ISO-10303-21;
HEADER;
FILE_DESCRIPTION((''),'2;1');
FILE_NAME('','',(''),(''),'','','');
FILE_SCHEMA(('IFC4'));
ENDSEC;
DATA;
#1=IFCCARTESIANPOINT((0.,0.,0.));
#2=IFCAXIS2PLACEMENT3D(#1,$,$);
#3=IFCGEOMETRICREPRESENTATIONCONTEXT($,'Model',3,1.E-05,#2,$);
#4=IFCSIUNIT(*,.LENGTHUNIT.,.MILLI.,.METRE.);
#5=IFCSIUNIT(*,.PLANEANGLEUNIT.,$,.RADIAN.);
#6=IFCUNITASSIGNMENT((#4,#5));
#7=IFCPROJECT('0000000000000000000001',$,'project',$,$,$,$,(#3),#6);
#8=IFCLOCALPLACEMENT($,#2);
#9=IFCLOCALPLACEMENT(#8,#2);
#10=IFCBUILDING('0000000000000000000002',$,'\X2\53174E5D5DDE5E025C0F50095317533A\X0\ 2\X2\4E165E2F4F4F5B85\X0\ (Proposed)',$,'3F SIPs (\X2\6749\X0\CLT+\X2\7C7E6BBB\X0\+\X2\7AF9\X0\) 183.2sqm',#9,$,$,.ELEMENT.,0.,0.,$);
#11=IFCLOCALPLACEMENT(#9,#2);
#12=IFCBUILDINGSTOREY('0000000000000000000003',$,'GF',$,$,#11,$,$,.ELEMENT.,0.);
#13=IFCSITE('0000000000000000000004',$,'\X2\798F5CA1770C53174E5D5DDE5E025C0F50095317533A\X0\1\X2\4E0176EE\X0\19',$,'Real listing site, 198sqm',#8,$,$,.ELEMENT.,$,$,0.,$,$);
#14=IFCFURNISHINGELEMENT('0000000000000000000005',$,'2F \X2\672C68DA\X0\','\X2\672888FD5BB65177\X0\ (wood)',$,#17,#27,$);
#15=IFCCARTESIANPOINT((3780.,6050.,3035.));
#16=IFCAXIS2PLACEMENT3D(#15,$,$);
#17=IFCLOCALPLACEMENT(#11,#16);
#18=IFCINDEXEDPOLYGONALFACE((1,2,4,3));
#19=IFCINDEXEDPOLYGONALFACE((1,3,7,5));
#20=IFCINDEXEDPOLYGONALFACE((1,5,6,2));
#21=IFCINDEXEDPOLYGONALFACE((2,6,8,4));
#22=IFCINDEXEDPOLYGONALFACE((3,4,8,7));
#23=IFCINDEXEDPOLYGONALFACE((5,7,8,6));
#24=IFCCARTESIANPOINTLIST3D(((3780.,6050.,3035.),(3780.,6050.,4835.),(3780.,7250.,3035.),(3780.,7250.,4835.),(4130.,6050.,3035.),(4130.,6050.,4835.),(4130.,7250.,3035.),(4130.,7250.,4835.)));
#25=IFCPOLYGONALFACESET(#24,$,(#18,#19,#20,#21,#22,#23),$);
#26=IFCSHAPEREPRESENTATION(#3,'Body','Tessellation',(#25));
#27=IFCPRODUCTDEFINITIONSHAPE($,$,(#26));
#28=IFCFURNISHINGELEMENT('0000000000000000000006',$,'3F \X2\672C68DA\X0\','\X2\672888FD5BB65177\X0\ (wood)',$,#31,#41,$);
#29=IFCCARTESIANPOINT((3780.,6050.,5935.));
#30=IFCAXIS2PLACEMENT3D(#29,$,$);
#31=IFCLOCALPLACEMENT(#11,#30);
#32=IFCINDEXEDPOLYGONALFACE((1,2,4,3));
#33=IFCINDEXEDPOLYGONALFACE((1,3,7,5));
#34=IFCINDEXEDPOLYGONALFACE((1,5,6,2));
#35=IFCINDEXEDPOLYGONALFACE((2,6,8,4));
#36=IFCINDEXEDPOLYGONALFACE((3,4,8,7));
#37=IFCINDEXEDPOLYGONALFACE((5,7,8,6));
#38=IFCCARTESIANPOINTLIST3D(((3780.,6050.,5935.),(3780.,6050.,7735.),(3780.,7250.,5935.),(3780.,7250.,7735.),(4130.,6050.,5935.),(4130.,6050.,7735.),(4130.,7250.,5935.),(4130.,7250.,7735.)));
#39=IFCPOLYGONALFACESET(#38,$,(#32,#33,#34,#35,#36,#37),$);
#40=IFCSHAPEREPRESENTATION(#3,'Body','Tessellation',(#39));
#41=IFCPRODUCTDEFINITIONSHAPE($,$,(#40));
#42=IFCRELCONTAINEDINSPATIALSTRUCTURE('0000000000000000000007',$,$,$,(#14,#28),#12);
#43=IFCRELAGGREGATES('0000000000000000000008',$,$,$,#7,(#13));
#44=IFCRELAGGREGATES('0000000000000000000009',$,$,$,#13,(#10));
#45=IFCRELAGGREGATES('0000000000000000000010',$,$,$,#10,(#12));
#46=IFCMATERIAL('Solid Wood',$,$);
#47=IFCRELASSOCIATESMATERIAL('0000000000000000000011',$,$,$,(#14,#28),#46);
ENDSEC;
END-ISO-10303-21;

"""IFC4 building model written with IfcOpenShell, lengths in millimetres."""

from ifc_helpers import new_model, si_unit, frame, frame_2d, origin, place, context, project, spatial, rectangle, extrude, material, element, save


model = new_model("IFC4")

# Units and contexts
model_context = context("Model", 3, precision=1e-05, world=origin())
ifc_project = project(units=[si_unit("LENGTHUNIT", "METRE", prefix="MILLI"), si_unit("PLANEANGLEUNIT", "RADIAN")], contexts=[model_context])

# Site, building, storey
site_placement = place(None, origin())
site = spatial("IfcSite", under=ifc_project, at=site_placement, Name="福岡県北九州市小倉北区1丁目19", ObjectType="Real listing site, 198sqm", CompositionType="ELEMENT", RefElevation=0.0)
building_placement = place(site_placement, origin())
building = spatial("IfcBuilding", under=site, at=building_placement, Name="北九州市小倉北区 2世帯住宅 (Proposed)", ObjectType="3F SIPs (杉CLT+籾殻+竹) 183.2sqm", CompositionType="ELEMENT", ElevationOfRefHeight=0.0, ElevationOfTerrain=0.0)
storey_placement = place(building_placement, origin())
storey = spatial("IfcBuildingStorey", under=building, at=storey_placement, Name="GF", CompositionType="ELEMENT", Elevation=0.0)

# Shared definitions
ifc_material_1 = material(Name="Solid Wood")

# Furnishing elements
furnishing_1_placement = place(storey_placement, frame((3780.0, 6050.0, 3035.0)))
element("IfcFurnishingElement", 1, at=furnishing_1_placement, inside=storey, material=ifc_material_1, Name="2F 本棚", Description="木製家具 (wood)", context=model_context, shape_type="SweptSolid", body=[
    extrude(rectangle(XDim=350.0, YDim=1200.0, at=frame_2d((175.0, 600.0))), frame((3780.0, 6050.0, 3035.0)), (0.0, 0.0, 1.0), 1800.0),
])
furnishing_2_placement = place(storey_placement, frame((3780.0, 6050.0, 5935.0)))
element("IfcFurnishingElement", 2, at=furnishing_2_placement, inside=storey, material=ifc_material_1, Name="3F 本棚", Description="木製家具 (wood)", context=model_context, shape_type="SweptSolid", body=[
    extrude(rectangle(XDim=350.0, YDim=1200.0, at=frame_2d((175.0, 600.0))), frame((3780.0, 6050.0, 5935.0)), (0.0, 0.0, 1.0), 1800.0),
])

save(model, "model.ifc")
